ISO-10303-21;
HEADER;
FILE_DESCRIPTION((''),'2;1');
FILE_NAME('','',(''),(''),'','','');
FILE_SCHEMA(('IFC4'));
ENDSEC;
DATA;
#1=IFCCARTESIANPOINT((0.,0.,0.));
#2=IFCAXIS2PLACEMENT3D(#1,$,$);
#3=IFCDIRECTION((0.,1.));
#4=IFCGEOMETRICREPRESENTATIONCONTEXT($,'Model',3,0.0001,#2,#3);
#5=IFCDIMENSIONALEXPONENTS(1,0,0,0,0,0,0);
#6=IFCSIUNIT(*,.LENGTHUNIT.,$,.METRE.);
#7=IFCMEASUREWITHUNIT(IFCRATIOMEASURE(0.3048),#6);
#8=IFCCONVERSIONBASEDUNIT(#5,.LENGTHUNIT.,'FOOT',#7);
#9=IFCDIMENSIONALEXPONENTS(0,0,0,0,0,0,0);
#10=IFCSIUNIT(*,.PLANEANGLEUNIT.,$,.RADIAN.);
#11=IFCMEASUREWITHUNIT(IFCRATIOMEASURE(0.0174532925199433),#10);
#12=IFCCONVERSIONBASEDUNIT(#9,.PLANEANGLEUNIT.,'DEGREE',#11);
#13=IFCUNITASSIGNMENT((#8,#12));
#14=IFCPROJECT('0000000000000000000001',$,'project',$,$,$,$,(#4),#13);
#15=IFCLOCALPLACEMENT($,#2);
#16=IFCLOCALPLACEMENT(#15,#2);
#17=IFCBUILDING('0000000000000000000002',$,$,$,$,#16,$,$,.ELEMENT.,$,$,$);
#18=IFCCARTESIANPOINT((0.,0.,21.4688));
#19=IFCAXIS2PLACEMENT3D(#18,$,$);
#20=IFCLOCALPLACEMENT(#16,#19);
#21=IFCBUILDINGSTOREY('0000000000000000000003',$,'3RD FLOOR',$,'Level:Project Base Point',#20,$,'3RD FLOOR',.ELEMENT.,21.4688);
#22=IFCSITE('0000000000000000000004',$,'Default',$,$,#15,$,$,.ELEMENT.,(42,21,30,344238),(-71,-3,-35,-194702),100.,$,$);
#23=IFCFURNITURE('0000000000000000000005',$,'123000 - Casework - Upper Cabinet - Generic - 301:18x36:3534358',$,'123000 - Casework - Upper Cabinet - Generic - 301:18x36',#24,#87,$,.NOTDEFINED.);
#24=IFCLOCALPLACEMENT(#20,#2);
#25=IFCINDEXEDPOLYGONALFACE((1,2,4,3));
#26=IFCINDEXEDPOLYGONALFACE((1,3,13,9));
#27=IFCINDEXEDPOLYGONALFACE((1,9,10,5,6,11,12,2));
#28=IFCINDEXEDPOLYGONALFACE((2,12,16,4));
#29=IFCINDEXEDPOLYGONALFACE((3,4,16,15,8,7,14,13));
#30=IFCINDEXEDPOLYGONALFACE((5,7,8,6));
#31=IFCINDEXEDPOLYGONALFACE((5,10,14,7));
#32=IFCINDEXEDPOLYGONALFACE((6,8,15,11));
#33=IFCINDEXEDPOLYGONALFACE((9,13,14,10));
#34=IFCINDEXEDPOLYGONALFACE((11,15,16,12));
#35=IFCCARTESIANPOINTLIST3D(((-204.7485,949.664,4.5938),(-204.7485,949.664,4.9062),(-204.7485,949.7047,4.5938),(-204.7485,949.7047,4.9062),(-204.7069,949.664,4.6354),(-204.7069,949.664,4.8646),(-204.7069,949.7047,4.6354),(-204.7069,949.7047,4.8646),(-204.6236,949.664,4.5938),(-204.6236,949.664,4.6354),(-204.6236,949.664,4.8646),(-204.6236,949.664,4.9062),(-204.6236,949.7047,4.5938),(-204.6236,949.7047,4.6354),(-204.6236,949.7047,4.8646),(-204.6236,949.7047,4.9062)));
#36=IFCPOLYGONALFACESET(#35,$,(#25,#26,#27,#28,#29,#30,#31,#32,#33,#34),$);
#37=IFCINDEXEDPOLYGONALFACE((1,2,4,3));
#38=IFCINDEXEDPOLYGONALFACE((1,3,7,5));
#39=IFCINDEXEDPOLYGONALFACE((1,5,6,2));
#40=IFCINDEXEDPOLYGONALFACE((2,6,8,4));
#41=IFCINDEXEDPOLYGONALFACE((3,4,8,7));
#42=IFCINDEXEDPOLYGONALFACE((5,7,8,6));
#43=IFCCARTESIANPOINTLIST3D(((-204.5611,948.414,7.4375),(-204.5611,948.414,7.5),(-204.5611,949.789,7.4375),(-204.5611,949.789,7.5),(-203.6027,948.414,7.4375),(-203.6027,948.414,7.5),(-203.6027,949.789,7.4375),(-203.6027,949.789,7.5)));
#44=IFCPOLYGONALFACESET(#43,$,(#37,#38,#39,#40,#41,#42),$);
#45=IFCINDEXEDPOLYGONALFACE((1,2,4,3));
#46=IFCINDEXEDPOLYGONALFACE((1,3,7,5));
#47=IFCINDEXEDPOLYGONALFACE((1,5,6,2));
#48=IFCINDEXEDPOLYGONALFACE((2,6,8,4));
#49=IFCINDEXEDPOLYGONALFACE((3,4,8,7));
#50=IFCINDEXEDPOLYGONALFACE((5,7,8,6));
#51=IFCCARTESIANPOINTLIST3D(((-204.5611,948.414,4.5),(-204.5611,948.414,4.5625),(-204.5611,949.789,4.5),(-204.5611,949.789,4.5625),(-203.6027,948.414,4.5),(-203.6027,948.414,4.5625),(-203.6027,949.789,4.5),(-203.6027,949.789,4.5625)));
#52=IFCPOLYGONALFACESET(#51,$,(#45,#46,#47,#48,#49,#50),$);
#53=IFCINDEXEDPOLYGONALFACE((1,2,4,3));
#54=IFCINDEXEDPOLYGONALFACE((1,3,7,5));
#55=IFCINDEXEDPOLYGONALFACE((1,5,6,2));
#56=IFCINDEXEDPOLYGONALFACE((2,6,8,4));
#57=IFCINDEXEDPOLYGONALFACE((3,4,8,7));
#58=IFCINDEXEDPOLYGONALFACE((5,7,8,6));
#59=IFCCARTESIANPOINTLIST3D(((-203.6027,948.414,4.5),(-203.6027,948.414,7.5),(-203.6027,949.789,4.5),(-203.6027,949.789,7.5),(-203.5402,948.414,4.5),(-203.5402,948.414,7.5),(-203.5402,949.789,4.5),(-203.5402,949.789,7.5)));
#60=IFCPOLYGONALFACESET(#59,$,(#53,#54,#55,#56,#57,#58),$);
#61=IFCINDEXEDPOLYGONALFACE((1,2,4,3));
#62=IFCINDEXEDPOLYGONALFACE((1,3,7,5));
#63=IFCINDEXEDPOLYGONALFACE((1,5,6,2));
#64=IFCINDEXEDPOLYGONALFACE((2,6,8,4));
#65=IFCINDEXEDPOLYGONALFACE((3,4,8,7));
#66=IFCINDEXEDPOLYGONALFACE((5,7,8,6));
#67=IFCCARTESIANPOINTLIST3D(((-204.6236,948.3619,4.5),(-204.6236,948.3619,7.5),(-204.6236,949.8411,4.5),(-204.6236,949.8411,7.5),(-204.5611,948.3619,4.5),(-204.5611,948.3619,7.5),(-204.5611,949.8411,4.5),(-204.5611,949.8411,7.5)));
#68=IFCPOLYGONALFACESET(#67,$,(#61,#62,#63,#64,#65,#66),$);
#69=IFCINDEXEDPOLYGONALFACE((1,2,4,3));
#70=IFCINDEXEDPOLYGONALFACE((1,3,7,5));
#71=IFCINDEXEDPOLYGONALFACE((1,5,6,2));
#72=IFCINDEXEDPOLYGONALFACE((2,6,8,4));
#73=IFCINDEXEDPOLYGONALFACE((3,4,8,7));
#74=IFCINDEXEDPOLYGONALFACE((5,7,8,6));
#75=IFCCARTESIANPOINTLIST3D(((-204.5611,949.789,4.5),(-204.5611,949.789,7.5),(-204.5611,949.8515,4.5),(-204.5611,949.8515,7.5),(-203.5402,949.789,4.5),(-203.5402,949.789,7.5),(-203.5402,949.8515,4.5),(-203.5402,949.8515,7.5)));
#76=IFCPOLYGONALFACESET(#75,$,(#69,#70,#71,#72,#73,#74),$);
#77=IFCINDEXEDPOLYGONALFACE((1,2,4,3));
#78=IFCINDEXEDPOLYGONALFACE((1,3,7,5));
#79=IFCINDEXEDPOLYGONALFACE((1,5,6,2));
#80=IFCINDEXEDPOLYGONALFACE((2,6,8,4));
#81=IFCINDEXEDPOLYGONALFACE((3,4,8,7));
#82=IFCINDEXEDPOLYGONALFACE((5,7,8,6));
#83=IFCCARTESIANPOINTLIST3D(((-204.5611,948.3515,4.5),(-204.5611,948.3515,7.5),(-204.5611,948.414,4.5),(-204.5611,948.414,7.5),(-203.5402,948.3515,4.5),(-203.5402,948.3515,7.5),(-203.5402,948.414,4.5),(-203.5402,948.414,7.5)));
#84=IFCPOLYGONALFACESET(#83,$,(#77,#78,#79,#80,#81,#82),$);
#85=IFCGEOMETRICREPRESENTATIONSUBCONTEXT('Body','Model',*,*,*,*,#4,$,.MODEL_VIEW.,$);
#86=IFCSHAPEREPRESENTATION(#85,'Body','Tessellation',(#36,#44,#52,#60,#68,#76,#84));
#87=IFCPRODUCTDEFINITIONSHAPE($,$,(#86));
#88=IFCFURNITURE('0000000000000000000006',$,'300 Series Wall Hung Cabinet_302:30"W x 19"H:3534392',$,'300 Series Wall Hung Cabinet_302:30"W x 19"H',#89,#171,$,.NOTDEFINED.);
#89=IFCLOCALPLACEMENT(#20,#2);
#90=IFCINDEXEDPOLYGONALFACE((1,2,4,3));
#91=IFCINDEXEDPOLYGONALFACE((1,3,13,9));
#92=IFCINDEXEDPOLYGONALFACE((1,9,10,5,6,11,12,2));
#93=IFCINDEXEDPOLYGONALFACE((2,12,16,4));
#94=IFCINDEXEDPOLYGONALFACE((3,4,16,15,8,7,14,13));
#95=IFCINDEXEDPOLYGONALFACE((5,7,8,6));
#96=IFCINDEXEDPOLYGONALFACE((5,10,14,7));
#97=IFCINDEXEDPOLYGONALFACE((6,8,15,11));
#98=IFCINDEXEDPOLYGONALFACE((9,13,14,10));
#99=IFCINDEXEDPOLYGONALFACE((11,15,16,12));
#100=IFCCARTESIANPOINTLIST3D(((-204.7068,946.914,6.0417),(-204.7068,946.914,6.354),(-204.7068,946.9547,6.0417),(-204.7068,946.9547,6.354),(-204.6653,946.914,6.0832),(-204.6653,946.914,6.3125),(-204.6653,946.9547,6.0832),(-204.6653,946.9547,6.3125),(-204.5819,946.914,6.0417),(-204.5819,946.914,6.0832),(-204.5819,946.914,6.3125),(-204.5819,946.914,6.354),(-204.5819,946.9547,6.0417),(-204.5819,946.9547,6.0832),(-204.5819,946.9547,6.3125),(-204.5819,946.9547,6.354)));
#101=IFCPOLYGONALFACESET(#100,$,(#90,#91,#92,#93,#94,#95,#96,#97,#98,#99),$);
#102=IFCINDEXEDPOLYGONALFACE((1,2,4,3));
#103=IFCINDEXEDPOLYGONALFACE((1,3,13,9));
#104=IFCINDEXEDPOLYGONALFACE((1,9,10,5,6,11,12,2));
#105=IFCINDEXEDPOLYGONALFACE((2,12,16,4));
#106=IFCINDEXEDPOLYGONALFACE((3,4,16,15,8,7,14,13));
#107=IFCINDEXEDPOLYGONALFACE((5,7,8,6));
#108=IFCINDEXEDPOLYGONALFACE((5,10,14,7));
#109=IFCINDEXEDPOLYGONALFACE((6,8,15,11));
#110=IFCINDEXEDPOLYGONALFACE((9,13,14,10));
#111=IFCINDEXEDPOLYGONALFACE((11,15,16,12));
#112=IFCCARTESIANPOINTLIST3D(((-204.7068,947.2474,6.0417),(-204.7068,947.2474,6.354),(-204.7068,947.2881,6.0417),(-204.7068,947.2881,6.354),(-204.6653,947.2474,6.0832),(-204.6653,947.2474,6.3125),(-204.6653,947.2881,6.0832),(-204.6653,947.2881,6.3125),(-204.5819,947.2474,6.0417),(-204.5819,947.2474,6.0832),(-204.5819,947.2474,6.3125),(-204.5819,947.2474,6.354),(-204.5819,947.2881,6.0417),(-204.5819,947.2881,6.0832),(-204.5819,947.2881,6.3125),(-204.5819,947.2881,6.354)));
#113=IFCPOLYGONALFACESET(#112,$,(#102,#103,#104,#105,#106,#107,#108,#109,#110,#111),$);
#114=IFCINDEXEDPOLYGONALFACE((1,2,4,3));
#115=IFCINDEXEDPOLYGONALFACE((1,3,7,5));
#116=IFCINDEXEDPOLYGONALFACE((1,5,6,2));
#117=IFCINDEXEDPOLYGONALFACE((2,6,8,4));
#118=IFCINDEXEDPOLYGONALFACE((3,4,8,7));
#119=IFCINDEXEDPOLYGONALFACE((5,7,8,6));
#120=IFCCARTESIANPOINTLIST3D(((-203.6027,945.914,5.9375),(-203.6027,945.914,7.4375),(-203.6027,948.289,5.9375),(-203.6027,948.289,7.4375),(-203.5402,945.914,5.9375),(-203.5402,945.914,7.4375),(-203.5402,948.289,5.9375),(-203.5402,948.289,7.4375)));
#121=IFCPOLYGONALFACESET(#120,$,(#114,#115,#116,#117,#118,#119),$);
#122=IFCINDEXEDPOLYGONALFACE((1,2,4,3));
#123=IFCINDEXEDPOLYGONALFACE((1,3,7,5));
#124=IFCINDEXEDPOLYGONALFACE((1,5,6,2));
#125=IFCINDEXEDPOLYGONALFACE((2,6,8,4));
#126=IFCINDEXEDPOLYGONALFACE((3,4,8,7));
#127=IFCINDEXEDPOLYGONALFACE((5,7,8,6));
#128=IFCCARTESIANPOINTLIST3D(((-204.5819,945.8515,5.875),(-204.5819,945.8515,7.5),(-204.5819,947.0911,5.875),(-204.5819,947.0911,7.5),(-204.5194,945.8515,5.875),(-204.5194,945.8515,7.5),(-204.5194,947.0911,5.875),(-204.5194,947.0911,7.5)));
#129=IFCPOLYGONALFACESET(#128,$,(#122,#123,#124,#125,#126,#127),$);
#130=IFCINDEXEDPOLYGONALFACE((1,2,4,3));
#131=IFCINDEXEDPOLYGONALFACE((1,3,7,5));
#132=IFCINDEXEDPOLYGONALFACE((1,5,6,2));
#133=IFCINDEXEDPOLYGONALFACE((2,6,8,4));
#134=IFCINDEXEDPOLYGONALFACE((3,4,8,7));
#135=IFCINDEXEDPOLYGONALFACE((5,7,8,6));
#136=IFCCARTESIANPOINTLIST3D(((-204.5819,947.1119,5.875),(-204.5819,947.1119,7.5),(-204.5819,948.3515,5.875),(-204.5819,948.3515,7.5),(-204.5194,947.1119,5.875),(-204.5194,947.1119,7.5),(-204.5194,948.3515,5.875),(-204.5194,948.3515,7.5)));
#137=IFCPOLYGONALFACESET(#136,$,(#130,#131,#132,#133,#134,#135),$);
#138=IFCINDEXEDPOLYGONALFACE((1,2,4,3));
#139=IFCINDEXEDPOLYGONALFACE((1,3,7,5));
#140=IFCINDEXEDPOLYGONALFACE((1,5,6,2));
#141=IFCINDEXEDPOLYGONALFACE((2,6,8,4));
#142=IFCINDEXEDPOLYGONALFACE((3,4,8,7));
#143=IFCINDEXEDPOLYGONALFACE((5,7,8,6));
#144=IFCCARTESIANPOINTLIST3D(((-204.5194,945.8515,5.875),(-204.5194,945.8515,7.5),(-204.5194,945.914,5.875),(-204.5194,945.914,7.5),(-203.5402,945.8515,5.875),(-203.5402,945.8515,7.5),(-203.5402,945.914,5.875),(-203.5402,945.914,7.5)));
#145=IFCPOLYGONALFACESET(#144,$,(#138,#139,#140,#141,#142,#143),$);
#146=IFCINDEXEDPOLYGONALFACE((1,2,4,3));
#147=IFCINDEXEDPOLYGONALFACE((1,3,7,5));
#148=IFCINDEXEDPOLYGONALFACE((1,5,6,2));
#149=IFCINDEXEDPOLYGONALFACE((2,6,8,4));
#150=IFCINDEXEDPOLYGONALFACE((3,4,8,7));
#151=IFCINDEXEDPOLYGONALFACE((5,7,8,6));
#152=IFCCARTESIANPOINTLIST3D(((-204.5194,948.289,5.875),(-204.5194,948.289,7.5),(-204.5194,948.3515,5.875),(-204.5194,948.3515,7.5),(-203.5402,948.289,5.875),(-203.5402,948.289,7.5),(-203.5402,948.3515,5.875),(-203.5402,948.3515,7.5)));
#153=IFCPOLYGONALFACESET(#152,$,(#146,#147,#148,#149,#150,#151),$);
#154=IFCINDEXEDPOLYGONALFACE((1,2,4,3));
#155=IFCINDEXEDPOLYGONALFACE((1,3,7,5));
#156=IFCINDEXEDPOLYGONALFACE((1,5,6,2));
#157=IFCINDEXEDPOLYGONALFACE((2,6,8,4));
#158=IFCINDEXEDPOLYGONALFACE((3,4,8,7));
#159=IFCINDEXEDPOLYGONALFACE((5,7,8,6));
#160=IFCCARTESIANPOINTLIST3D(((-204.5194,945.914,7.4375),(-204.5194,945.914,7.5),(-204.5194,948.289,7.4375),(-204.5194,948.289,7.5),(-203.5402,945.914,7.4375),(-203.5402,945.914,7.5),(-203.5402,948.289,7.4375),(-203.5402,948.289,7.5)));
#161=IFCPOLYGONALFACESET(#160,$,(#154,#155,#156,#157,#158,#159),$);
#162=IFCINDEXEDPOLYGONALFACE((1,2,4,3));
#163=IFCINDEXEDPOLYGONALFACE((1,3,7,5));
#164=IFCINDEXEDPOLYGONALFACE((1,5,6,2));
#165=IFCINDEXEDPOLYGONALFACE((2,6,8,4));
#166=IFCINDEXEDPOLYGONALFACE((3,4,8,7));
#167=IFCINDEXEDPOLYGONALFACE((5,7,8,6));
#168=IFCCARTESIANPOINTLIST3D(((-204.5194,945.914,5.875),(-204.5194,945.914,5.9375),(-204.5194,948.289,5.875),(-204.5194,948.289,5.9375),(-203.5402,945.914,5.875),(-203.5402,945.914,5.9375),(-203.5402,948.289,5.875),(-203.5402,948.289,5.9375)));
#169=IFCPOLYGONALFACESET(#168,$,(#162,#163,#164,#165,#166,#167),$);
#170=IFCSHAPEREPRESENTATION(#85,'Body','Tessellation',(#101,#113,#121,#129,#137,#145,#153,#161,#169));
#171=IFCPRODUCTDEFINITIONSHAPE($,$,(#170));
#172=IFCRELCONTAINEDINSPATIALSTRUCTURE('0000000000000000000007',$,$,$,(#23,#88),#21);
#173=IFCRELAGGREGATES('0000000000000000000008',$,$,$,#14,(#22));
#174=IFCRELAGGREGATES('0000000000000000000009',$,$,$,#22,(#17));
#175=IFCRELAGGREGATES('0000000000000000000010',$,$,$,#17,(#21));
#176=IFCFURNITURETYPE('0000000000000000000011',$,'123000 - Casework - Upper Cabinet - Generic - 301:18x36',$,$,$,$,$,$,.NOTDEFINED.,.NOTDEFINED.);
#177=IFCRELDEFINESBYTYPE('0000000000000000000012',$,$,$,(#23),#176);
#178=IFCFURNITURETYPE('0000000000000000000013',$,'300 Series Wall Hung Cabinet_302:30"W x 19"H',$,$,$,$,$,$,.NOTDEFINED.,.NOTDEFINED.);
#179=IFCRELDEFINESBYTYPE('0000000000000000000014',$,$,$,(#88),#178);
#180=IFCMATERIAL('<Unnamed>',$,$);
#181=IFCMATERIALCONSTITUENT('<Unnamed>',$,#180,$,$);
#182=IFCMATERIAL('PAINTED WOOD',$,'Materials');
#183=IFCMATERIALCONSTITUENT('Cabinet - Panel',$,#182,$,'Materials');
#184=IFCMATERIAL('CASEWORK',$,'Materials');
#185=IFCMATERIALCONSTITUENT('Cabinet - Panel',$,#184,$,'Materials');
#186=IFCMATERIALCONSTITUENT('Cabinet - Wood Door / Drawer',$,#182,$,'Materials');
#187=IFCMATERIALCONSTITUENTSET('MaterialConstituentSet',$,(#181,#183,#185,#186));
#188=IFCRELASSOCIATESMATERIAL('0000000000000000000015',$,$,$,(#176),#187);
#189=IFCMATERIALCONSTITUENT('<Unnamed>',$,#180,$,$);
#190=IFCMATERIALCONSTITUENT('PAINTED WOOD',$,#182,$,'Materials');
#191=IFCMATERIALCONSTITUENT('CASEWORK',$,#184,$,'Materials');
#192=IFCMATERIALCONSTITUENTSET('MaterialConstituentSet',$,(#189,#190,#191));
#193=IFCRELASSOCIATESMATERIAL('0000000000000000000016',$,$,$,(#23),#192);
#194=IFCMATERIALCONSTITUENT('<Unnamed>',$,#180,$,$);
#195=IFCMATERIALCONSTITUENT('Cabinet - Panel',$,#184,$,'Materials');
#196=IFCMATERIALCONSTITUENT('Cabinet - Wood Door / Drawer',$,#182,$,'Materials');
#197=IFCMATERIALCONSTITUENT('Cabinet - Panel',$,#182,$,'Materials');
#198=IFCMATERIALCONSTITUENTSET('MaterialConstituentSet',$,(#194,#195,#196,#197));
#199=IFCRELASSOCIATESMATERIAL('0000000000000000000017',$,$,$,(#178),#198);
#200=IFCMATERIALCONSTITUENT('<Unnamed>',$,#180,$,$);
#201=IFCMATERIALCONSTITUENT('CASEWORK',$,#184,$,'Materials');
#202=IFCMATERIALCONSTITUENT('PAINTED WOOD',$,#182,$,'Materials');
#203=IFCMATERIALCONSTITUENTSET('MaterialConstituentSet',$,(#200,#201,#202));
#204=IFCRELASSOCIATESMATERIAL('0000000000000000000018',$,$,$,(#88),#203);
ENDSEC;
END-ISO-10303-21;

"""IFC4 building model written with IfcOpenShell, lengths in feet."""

from ifc_helpers import new_model, entity, si_unit, converted_unit, direction, frame, frame_2d, origin, origin_2d_with_axis, place, context, subcontext, project, spatial, polyline, rectangle, outline, extrude, source, transform, mapped, material, constituent, constituent_set, type_object, type_shapes, element, save


model = new_model("IFC4")

# Units and contexts
model_context = context("Model", 3, precision=0.0001, world=origin(), true_north=direction((0.0, 1.0)))
body_context = subcontext(model_context, "Body", "Model", "MODEL_VIEW")
ifc_project = project(units=[converted_unit("LENGTHUNIT", "FOOT", entity("IfcRatioMeasure", 0.3048), si_unit("LENGTHUNIT", "METRE"), dimensions=[1, 0, 0, 0, 0, 0, 0]), converted_unit("PLANEANGLEUNIT", "DEGREE", entity("IfcRatioMeasure", 0.0174532925199433), si_unit("PLANEANGLEUNIT", "RADIAN"), dimensions=[0, 0, 0, 0, 0, 0, 0])], contexts=[model_context])

# Site, building, storey
site_placement = place(None, origin())
site = spatial("IfcSite", under=ifc_project, at=site_placement, Name="Default", CompositionType="ELEMENT", RefLatitude=(42, 21, 30, 344238), RefLongitude=(-71, -3, -35, -194702), RefElevation=100.0)
building_placement = place(site_placement, origin())
building = spatial("IfcBuilding", under=site, at=building_placement, CompositionType="ELEMENT")
storey_placement = place(building_placement, frame((0.0, 0.0, 21.4688)))
storey = spatial("IfcBuildingStorey", under=building, at=storey_placement, Name="3RD FLOOR", ObjectType="Level:Project Base Point", LongName="3RD FLOOR", CompositionType="ELEMENT", Elevation=21.4688)

# Furniture
ifc_material_1 = material(Name="CASEWORK", Category="Materials")
ifc_material_2 = material(Name="<Unnamed>")
ifc_material_3 = material(Name="PAINTED WOOD", Category="Materials")
ifc_constituent_1 = constituent(ifc_material_2, Name="<Unnamed>")
ifc_constituent_2 = constituent(ifc_material_3, Name="PAINTED WOOD", Category="Materials")
ifc_constituent_3 = constituent(ifc_material_1, Name="CASEWORK", Category="Materials")
ifc_constituent_set_1 = constituent_set(constituents=[ifc_constituent_1, ifc_constituent_2, ifc_constituent_3], Name="MaterialConstituentSet")
ifc_constituent_4 = constituent(ifc_material_2, Name="<Unnamed>")
ifc_constituent_5 = constituent(ifc_material_3, Name="Cabinet - Panel", Category="Materials")
ifc_constituent_6 = constituent(ifc_material_1, Name="Cabinet - Panel", Category="Materials")
ifc_constituent_7 = constituent(ifc_material_3, Name="Cabinet - Wood Door / Drawer", Category="Materials")
ifc_constituent_set_2 = constituent_set(constituents=[ifc_constituent_4, ifc_constituent_5, ifc_constituent_6, ifc_constituent_7], Name="MaterialConstituentSet")
furniture_type_1 = type_object("IfcFurnitureType", Name="123000 - Casework - Upper Cabinet - Generic - 301:18x36", AssemblyPlace="NOTDEFINED", PredefinedType="NOTDEFINED", material=ifc_constituent_set_2)
shared_shape_1 = source(origin(), body_context, "Body", "SweptSolid", [
    extrude(outline(polyline([(0.1146, -0.0521), (0.1562, -0.0521), (0.1562, 0.0729), (-0.1562, 0.0729), (-0.1562, -0.0521), (-0.1146, -0.0521), (-0.1146, 0.0313), (0.1146, 0.0313), (0.1146, -0.0521)])), frame((0.1468, 0.0729, 0.25), z_axis=(1.0, 0.0, 0.0), x_axis=(0.0, 0.0, 1.0)), (0.0, 0.0, 1.0), 0.0407),
    extrude(rectangle(XDim=1.375, YDim=0.9583, at=frame_2d((0.0, 0.0), x_axis=(1.0, 0.0))), frame((0.75, 0.6666, 2.9375), z_axis=(0.0, 0.0, 1.0), x_axis=(-1.0, 0.0, 0.0)), (0.0, 0.0, 1.0), 0.0625),
    extrude(rectangle(XDim=1.375, YDim=0.9583, at=frame_2d((0.0, 0.0), x_axis=(1.0, 0.0))), frame((0.75, 0.6666, 0.0), z_axis=(0.0, 0.0, 1.0), x_axis=(-1.0, 0.0, 0.0)), (0.0, 0.0, 1.0), 0.0625),
    extrude(rectangle(XDim=0.0625, YDim=1.375, at=origin_2d_with_axis()), frame((0.75, 1.177, 0.0), z_axis=(0.0, 0.0, 1.0), x_axis=(0.0, 1.0, 0.0)), (0.0, 0.0, 1.0), 3.0),
    extrude(rectangle(XDim=0.0625, YDim=1.4792, at=origin_2d_with_axis()), frame((0.75, 0.1562, 0.0), z_axis=(0.0, 0.0, 1.0), x_axis=(0.0, -1.0, 0.0)), (0.0, 0.0, 1.0), 3.0),
    extrude(rectangle(XDim=0.0625, YDim=1.0208, at=origin_2d_with_axis()), frame((0.0312, 0.6979, 0.0), z_axis=(0.0, 0.0, 1.0), x_axis=(-1.0, 0.0, 0.0)), (0.0, 0.0, 1.0), 3.0),
    extrude(rectangle(XDim=0.0625, YDim=1.0208, at=origin_2d_with_axis()), frame((1.4688, 0.6979, 0.0), z_axis=(0.0, 0.0, 1.0), x_axis=(-1.0, 0.0, 0.0)), (0.0, 0.0, 1.0), 3.0),
])
type_shapes(furniture_type_1, [shared_shape_1])
furniture_1_placement = place(storey_placement, frame((-204.7485, 949.8515, 4.5), z_axis=(0.0, 0.0, 1.0), x_axis=(0.0, -1.0, 0.0)))
element("IfcFurniture", 1, at=furniture_1_placement, inside=storey, type_object=furniture_type_1, material=ifc_constituent_set_1, Name="123000 - Casework - Upper Cabinet - Generic - 301:18x36:3534358", ObjectType="123000 - Casework - Upper Cabinet - Generic - 301:18x36", PredefinedType="NOTDEFINED", context=body_context, shape_type="MappedRepresentation", body=[
    mapped(shared_shape_1, transform((0.0, 0.0, 0.0), scale=1.0)),
])
ifc_constituent_8 = constituent(ifc_material_2, Name="<Unnamed>")
ifc_constituent_9 = constituent(ifc_material_1, Name="CASEWORK", Category="Materials")
ifc_constituent_10 = constituent(ifc_material_3, Name="PAINTED WOOD", Category="Materials")
ifc_constituent_set_3 = constituent_set(constituents=[ifc_constituent_8, ifc_constituent_9, ifc_constituent_10], Name="MaterialConstituentSet")
ifc_constituent_11 = constituent(ifc_material_2, Name="<Unnamed>")
ifc_constituent_12 = constituent(ifc_material_1, Name="Cabinet - Panel", Category="Materials")
ifc_constituent_13 = constituent(ifc_material_3, Name="Cabinet - Wood Door / Drawer", Category="Materials")
ifc_constituent_14 = constituent(ifc_material_3, Name="Cabinet - Panel", Category="Materials")
ifc_constituent_set_4 = constituent_set(constituents=[ifc_constituent_11, ifc_constituent_12, ifc_constituent_13, ifc_constituent_14], Name="MaterialConstituentSet")
furniture_type_2 = type_object("IfcFurnitureType", Name="300 Series Wall Hung Cabinet_302:30\"W x 19\"H", AssemblyPlace="NOTDEFINED", PredefinedType="NOTDEFINED", material=ifc_constituent_set_4)
shared_shape_2 = source(origin(), body_context, "Body", "SweptSolid", [
    extrude(outline(polyline([(-0.0521, -0.1146), (-0.0521, -0.1562), (0.0729, -0.1562), (0.0729, 0.1562), (-0.0521, 0.1562), (-0.0521, 0.1146), (0.0313, 0.1146), (0.0313, -0.1146), (-0.0521, -0.1146)])), frame((1.0625, 1.0937, 0.3229), z_axis=(-1.0, 0.0, 0.0), x_axis=(0.0, 1.0, 0.0)), (0.0, 0.0, -1.0), 0.0407),
    extrude(outline(polyline([(-0.0521, -0.1146), (-0.0521, -0.1562), (0.0729, -0.1562), (0.0729, 0.1562), (-0.0521, 0.1562), (-0.0521, 0.1146), (0.0313, 0.1146), (0.0313, -0.1146), (-0.0521, -0.1146)])), frame((1.3958, 1.0937, 0.3229), z_axis=(-1.0, 0.0, 0.0), x_axis=(0.0, 1.0, 0.0)), (0.0, 0.0, -1.0), 0.0407),
    extrude(rectangle(XDim=0.0625, YDim=2.375, at=frame_2d((0.0, 0.0), x_axis=(1.0, 0.0))), frame((1.25, 0.0313, 0.0625), z_axis=(0.0, 0.0, 1.0), x_axis=(0.0, 1.0, 0.0)), (0.0, 0.0, 1.0), 1.5),
    extrude(rectangle(XDim=0.0625, YDim=1.2396, at=origin_2d_with_axis()), frame((0.6198, 1.0104, 0.0), z_axis=(0.0, 0.0, 1.0), x_axis=(0.0, 1.0, 0.0)), (0.0, 0.0, 1.0), 1.625),
    extrude(rectangle(XDim=0.0625, YDim=1.2396, at=frame_2d((0.0, 0.0), x_axis=(1.0, 0.0))), frame((1.8802, 1.0104, 0.0), z_axis=(0.0, 0.0, 1.0), x_axis=(0.0, 1.0, 0.0)), (0.0, 0.0, 1.0), 1.625),
    extrude(rectangle(XDim=0.0625, YDim=0.9792, at=frame_2d((0.0, 0.0), x_axis=(1.0, 0.0))), frame((0.0313, 0.4896, 0.0)), (0.0, 0.0, 1.0), 1.625),
    extrude(rectangle(XDim=0.0625, YDim=0.9792, at=frame_2d((0.0, 0.0), x_axis=(1.0, 0.0))), frame((2.4688, 0.4896, 0.0)), (0.0, 0.0, 1.0), 1.625),
    extrude(rectangle(XDim=2.375, YDim=0.9792, at=frame_2d((0.0, 0.0), x_axis=(1.0, 0.0))), frame((1.25, 0.4896, 1.5625), z_axis=(0.0, 0.0, 1.0), x_axis=(-1.0, 0.0, 0.0)), (0.0, 0.0, 1.0), 0.0625),
    extrude(rectangle(XDim=2.375, YDim=0.9792, at=frame_2d((0.0, 0.0), x_axis=(1.0, 0.0))), frame((1.25, 0.4896, 0.0), z_axis=(0.0, 0.0, 1.0), x_axis=(-1.0, 0.0, 0.0)), (0.0, 0.0, 1.0), 0.0625),
])
type_shapes(furniture_type_2, [shared_shape_2])
furniture_2_placement = place(storey_placement, frame((-203.5402, 945.8515, 5.875), z_axis=(0.0, 0.0, 1.0), x_axis=(0.0, 1.0, 0.0)))
element("IfcFurniture", 2, at=furniture_2_placement, inside=storey, type_object=furniture_type_2, material=ifc_constituent_set_3, Name="300 Series Wall Hung Cabinet_302:30\"W x 19\"H:3534392", ObjectType="300 Series Wall Hung Cabinet_302:30\"W x 19\"H", PredefinedType="NOTDEFINED", context=body_context, shape_type="MappedRepresentation", body=[
    mapped(shared_shape_2, transform((0.0, 0.0, 0.0), scale=1.0)),
])

save(model, "model.ifc")
